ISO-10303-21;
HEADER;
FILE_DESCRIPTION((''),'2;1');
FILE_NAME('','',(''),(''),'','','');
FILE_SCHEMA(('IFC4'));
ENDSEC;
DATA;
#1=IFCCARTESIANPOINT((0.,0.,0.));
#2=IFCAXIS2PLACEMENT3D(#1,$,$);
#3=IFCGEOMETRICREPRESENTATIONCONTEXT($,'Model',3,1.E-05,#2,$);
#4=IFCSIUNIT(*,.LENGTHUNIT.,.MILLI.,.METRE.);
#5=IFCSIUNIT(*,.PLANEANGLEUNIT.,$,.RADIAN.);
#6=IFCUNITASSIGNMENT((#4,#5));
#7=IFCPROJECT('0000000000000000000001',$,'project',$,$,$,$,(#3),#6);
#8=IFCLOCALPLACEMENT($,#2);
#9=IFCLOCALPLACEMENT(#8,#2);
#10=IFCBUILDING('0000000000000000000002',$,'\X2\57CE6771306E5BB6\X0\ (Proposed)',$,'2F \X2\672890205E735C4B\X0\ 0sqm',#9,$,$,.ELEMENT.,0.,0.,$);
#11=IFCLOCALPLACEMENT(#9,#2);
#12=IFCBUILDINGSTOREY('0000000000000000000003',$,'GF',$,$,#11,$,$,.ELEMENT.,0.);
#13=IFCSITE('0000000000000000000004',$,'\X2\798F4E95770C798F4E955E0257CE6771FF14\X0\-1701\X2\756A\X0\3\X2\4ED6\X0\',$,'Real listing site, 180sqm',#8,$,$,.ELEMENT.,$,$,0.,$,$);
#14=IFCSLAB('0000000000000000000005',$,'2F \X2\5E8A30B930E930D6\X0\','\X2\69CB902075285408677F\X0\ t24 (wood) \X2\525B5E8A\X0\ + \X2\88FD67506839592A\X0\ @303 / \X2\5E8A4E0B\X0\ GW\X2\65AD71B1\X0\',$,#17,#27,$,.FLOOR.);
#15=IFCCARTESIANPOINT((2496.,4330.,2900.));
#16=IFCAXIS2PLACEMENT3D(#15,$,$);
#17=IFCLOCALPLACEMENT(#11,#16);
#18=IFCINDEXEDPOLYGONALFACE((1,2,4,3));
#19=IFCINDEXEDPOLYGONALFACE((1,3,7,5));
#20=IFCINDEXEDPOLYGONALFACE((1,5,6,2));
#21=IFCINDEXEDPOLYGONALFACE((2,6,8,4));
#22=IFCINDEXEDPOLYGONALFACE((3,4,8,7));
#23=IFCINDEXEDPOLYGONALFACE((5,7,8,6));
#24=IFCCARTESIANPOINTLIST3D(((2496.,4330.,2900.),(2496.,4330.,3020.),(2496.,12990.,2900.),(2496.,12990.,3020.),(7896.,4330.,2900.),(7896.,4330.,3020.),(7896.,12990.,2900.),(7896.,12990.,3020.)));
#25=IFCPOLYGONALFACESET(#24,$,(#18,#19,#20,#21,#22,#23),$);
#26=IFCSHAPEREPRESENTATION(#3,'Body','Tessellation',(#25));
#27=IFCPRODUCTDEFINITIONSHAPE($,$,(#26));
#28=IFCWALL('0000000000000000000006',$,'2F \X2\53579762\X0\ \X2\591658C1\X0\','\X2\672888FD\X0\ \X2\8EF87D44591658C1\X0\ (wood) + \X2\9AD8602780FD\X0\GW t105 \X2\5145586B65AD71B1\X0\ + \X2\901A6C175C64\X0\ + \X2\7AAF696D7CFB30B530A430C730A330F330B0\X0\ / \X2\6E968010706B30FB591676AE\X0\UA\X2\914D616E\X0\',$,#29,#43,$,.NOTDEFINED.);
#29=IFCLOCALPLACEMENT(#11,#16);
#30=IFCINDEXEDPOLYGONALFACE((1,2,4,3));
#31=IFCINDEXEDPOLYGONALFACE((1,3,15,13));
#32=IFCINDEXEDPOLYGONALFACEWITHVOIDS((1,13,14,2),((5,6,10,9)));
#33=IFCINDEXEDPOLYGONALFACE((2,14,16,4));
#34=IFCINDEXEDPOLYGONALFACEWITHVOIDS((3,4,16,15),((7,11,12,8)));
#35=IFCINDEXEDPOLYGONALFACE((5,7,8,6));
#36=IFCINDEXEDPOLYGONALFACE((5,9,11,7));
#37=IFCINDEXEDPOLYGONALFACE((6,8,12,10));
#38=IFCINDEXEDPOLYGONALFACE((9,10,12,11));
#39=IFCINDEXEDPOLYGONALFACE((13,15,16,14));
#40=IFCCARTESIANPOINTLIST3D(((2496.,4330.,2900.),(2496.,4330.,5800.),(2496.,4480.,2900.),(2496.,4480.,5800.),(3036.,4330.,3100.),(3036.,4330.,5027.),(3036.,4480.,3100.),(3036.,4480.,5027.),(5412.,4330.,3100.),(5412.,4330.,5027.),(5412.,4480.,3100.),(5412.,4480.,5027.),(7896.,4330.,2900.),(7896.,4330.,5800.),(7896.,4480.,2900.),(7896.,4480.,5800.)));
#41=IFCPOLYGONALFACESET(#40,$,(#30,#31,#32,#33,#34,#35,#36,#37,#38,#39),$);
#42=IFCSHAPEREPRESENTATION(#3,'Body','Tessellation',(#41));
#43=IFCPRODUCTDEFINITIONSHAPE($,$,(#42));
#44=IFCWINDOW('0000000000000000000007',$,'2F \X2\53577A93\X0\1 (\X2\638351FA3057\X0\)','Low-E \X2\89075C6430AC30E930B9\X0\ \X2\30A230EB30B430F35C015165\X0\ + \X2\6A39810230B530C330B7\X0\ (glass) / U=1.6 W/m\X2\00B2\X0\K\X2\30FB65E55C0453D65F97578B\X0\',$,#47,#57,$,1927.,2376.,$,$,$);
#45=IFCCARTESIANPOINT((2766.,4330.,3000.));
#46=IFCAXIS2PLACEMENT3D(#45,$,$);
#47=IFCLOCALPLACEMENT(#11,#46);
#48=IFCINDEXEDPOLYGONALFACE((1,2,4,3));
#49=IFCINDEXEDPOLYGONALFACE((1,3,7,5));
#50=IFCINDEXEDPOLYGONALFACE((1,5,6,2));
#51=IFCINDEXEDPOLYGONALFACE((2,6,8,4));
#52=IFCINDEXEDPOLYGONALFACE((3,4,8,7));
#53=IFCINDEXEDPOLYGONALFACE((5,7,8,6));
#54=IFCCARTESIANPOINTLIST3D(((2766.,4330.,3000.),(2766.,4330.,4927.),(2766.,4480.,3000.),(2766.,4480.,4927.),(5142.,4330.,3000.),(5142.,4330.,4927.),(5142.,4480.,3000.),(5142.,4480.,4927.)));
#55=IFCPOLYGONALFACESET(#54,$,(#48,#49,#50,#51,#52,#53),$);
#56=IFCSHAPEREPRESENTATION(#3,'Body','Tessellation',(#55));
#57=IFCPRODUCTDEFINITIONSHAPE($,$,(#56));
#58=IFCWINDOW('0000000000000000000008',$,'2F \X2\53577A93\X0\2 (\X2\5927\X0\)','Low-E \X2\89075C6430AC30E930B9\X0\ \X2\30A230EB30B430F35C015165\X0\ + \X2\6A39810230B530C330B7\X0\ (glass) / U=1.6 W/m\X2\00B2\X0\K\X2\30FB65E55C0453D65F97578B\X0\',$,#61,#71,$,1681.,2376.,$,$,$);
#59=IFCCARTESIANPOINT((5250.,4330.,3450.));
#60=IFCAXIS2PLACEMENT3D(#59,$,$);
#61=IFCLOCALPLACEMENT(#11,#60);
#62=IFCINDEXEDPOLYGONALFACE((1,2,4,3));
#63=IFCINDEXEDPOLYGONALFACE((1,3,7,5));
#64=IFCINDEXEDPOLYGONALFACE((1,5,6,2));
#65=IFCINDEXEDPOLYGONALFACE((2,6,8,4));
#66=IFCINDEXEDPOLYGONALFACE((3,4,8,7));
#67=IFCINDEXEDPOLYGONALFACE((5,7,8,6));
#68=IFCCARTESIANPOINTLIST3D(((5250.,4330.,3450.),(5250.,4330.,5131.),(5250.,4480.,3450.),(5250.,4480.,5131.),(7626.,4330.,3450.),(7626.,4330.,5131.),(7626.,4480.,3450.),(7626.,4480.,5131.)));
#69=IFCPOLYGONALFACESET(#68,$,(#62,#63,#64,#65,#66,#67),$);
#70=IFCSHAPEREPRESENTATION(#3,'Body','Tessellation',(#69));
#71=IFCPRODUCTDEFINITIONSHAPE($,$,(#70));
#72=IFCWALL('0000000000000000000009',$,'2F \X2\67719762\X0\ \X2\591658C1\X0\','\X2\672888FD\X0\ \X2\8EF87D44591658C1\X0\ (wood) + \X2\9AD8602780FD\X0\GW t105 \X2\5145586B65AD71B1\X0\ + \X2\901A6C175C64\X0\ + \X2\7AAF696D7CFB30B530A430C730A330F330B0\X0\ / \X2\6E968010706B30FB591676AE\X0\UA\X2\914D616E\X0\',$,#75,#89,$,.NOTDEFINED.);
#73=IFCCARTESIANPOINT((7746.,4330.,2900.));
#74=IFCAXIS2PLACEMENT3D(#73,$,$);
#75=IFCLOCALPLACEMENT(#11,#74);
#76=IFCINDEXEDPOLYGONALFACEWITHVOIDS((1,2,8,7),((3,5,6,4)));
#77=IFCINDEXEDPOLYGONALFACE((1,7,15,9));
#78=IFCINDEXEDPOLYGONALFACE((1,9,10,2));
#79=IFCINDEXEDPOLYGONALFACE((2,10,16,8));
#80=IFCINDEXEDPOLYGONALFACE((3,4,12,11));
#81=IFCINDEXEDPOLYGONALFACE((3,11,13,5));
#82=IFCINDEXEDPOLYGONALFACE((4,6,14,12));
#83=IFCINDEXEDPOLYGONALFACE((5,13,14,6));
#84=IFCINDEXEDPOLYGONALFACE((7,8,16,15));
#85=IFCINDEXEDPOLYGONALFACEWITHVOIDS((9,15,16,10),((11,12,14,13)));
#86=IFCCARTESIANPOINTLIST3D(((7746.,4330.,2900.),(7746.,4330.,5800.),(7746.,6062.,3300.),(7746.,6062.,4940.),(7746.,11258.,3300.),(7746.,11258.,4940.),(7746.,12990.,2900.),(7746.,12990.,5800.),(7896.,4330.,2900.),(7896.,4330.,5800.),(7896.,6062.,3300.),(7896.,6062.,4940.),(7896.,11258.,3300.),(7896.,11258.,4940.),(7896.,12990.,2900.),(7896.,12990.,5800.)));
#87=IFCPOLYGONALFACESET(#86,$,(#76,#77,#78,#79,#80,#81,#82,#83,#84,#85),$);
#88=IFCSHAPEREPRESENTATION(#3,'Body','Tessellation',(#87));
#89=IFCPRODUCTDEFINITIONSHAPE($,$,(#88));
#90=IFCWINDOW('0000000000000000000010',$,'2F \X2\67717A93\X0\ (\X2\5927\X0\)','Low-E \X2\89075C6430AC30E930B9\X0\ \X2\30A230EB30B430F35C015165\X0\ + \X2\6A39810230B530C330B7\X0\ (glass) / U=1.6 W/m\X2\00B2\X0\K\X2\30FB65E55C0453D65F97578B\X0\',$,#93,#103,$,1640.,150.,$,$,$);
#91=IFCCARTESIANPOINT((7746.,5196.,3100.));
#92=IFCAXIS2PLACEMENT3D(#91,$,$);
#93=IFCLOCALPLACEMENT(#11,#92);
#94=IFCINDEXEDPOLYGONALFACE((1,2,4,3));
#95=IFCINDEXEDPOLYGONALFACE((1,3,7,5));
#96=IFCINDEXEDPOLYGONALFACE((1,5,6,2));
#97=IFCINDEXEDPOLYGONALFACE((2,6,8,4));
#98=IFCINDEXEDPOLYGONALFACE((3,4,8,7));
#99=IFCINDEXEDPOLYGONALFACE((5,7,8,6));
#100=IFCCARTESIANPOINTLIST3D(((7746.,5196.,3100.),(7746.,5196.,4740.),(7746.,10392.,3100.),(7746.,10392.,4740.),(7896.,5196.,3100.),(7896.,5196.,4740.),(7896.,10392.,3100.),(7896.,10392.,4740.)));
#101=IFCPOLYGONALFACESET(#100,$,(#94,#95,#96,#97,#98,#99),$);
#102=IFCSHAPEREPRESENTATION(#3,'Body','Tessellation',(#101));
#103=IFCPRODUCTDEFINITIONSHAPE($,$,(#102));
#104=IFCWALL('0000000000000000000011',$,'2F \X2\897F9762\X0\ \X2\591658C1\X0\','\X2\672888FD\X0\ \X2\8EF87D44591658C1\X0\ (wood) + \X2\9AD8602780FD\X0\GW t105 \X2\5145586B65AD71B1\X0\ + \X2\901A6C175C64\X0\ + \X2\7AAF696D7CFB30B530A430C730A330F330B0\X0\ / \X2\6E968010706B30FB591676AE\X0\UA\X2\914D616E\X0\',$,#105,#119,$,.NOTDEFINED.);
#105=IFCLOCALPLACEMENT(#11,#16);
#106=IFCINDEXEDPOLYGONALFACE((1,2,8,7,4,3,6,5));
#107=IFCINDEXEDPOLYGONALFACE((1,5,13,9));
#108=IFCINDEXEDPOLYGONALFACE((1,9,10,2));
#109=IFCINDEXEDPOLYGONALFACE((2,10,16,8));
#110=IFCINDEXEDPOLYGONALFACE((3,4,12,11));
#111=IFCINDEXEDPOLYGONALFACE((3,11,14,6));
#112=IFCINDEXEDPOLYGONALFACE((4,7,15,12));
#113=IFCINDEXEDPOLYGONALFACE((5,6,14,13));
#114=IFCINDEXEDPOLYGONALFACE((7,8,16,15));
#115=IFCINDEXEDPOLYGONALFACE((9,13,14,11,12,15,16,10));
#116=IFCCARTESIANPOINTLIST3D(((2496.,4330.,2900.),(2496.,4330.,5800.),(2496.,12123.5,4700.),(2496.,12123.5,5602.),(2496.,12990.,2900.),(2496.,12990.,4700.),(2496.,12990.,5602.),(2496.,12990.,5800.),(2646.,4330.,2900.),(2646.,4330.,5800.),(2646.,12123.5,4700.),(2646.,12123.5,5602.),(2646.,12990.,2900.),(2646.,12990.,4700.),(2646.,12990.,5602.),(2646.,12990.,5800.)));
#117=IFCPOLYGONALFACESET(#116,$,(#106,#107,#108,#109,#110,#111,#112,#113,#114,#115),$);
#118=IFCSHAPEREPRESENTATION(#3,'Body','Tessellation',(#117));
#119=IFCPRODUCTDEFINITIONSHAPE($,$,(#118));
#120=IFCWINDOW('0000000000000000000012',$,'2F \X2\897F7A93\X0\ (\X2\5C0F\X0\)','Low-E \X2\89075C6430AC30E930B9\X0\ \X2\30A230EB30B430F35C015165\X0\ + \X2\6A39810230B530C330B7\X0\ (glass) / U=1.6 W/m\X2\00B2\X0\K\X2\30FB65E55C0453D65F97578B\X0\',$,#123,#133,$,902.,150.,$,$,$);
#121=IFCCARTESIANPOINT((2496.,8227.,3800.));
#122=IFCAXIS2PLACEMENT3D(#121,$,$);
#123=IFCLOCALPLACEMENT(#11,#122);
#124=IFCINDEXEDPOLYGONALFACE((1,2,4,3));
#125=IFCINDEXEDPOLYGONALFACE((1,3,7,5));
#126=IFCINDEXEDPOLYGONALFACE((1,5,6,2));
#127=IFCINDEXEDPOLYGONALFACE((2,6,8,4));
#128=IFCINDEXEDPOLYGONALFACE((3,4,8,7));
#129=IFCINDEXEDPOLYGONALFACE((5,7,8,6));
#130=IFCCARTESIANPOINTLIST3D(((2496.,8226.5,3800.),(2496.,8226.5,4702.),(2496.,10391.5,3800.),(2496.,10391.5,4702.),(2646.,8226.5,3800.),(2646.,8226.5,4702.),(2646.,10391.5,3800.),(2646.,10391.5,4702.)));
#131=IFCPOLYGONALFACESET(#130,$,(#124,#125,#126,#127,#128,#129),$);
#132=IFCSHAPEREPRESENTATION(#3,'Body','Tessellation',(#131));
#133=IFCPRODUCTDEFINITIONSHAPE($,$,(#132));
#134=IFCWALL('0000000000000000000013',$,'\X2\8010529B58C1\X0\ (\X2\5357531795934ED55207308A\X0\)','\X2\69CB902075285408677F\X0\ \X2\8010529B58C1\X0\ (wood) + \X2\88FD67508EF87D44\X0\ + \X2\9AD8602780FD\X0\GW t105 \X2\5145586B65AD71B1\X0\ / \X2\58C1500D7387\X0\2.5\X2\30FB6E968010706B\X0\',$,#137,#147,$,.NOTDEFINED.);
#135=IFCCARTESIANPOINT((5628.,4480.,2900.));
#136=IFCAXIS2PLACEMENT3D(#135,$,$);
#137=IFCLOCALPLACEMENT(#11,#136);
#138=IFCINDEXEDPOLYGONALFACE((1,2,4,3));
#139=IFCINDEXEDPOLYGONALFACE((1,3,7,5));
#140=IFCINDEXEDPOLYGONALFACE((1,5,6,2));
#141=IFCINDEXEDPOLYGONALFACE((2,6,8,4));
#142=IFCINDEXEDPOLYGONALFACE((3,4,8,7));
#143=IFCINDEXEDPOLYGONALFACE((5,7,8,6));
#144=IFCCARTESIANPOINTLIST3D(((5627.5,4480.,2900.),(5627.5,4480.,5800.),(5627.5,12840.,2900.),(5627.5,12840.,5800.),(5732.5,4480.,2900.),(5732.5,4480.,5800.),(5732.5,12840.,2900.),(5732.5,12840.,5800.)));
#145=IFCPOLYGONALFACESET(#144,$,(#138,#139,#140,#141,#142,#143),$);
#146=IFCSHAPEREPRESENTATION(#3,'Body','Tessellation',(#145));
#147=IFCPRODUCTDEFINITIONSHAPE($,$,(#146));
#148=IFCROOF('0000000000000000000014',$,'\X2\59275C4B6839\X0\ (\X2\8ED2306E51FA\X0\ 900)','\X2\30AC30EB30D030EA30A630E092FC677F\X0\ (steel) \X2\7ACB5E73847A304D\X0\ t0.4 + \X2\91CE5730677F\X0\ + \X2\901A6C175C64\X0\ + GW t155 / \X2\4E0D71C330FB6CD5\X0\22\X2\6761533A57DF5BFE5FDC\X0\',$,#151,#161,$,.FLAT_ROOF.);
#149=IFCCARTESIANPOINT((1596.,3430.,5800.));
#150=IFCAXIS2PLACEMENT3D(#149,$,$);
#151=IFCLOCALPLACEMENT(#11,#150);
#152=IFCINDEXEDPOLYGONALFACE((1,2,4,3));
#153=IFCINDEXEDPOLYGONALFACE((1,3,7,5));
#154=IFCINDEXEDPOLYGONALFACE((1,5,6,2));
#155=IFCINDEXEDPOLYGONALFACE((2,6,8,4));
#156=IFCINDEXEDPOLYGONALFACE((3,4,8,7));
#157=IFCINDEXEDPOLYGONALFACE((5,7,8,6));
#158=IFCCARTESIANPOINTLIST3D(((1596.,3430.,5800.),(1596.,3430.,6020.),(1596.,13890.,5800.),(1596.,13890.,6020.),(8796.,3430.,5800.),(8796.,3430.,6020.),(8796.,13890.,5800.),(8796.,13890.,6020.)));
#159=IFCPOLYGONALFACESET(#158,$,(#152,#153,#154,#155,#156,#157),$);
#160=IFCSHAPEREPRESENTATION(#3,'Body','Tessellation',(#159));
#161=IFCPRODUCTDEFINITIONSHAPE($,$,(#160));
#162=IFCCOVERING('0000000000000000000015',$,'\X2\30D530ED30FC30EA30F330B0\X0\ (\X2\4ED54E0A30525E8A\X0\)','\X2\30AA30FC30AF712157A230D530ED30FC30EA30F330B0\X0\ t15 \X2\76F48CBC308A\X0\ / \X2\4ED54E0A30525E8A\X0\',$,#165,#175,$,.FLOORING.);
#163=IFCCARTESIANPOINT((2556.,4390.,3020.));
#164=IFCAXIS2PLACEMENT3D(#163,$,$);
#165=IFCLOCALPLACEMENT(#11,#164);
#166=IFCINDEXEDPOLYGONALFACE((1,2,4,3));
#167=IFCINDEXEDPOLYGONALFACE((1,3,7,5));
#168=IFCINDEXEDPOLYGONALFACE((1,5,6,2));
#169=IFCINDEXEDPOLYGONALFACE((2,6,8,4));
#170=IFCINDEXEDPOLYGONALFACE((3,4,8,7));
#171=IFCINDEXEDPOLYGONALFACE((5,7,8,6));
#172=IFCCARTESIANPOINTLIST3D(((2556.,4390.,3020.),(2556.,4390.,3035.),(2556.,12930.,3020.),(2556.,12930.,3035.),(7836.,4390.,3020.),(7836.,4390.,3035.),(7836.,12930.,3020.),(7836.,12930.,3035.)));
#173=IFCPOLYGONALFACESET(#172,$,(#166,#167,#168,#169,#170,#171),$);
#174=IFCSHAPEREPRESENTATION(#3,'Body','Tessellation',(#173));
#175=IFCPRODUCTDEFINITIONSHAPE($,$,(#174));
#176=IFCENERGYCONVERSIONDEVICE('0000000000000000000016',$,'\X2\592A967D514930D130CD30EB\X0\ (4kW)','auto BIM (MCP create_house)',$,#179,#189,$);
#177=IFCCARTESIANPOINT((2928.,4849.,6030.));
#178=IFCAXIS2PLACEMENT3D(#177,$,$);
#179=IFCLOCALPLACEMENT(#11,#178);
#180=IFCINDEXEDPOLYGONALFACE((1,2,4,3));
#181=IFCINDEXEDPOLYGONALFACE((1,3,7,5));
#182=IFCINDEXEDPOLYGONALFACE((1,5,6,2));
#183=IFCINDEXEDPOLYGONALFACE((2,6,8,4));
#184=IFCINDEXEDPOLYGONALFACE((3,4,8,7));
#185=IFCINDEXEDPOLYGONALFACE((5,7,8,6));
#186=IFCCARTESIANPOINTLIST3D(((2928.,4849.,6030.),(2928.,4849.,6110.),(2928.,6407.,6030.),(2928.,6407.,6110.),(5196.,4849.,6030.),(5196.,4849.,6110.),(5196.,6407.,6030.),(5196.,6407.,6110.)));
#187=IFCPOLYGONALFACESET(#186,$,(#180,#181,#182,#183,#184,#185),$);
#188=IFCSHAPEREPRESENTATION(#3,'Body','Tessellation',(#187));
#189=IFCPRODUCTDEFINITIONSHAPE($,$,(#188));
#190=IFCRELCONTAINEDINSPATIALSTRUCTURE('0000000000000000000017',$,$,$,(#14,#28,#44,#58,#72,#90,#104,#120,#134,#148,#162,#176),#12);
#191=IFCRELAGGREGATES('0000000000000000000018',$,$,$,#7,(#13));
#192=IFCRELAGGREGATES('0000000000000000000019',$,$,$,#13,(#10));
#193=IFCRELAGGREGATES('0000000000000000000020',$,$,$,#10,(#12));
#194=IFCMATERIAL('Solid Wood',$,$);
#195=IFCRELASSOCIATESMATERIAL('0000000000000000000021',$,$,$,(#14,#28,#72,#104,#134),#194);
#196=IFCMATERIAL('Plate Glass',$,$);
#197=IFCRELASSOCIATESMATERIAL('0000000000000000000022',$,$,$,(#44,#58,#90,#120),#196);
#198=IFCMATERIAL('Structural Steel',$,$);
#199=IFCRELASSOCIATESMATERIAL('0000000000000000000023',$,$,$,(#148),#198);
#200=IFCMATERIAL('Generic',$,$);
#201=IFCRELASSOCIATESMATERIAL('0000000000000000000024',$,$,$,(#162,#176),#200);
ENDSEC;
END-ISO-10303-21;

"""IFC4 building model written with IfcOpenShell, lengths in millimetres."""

from ifc_helpers import new_model, si_unit, frame, frame_2d, origin, place, context, project, spatial, rectangle, extrude, material, element, fill, save


model = new_model("IFC4")

# Units and contexts
model_context = context("Model", 3, precision=1e-05, world=origin())
ifc_project = project(units=[si_unit("LENGTHUNIT", "METRE", prefix="MILLI"), si_unit("PLANEANGLEUNIT", "RADIAN")], contexts=[model_context])

# Site, building, storey
site_placement = place(None, origin())
site = spatial("IfcSite", under=ifc_project, at=site_placement, Name="福井県福井市城東４-1701番3他", ObjectType="Real listing site, 180sqm", CompositionType="ELEMENT", RefElevation=0.0)
building_placement = place(site_placement, origin())
building = spatial("IfcBuilding", under=site, at=building_placement, Name="城東の家 (Proposed)", ObjectType="2F 木造平屋 0sqm", CompositionType="ELEMENT", ElevationOfRefHeight=0.0, ElevationOfTerrain=0.0)
storey_placement = place(building_placement, origin())
storey = spatial("IfcBuildingStorey", under=building, at=storey_placement, Name="GF", CompositionType="ELEMENT", Elevation=0.0)

# Slab
ifc_material_1 = material(Name="Solid Wood")
slab_placement = place(storey_placement, frame((2496.0, 4330.0, 2900.0)))
element("IfcSlab", 1, at=slab_placement, inside=storey, material=ifc_material_1, Name="2F 床スラブ", Description="構造用合板 t24 (wood) 剛床 + 製材根太 @303 / 床下 GW断熱", PredefinedType="FLOOR", context=model_context, shape_type="SweptSolid", body=[
    extrude(rectangle(XDim=5400.0, YDim=8660.0, at=frame_2d((2700.0, 4330.0))), frame((2496.0, 4330.0, 2900.0)), (0.0, 0.0, 1.0), 120.0),
])

# Wall, openings, windows
wall_1_placement = place(storey_placement, frame((2496.0, 4330.0, 2900.0)))
wall_1 = element("IfcWall", 2, at=wall_1_placement, inside=storey, material=ifc_material_1, Name="2F 南面 外壁", Description="木製 軸組外壁 (wood) + 高性能GW t105 充填断熱 + 通気層 + 窯業系サイディング / 準耐火・外皮UA配慮", PredefinedType="NOTDEFINED", context=model_context, shape_type="SweptSolid", body=[
    extrude(rectangle(XDim=5400.0, YDim=150.0, at=frame_2d((2700.0, 75.0))), frame((2496.0, 4330.0, 2900.0)), (0.0, 0.0, 1.0), 2900.0),
])
opening_1_placement = place(storey_placement, frame((2766.0, 4330.0, 3000.0)))
opening_1 = element("IfcOpeningElement", 3, at=opening_1_placement, cuts=wall_1, PredefinedType="NOTDEFINED", context=model_context, shape_type="SweptSolid", body=[
    extrude(rectangle(XDim=2376.0, YDim=150.0, at=frame_2d((1188.0, 75.0))), frame((2766.0, 4330.0, 3000.0)), (0.0, 0.0, 1.0), 1927.0),
])
opening_2_placement = place(storey_placement, frame((5250.0, 4330.0, 3450.0)))
opening_2 = element("IfcOpeningElement", 4, at=opening_2_placement, cuts=wall_1, PredefinedType="NOTDEFINED", context=model_context, shape_type="SweptSolid", body=[
    extrude(rectangle(XDim=2376.0, YDim=150.0, at=frame_2d((1188.0, 75.0))), frame((5250.0, 4330.0, 3450.0)), (0.0, 0.0, 1.0), 1681.0),
])
ifc_material_2 = material(Name="Plate Glass")
window_1_placement = place(storey_placement, frame((2766.0, 4330.0, 3000.0)))
window_1 = element("IfcWindow", 5, at=window_1_placement, inside=storey, material=ifc_material_2, Name="2F 南窓1 (掃出し)", Description="Low-E 複層ガラス アルゴン封入 + 樹脂サッシ (glass) / U=1.6 W/m²K・日射取得型", OverallHeight=1927.0, OverallWidth=2376.0, context=model_context, shape_type="SweptSolid", body=[
    extrude(rectangle(XDim=2376.0, YDim=150.0, at=frame_2d((1188.0, 75.0))), frame((2766.0, 4330.0, 3000.0)), (0.0, 0.0, 1.0), 1927.0),
])
fill(opening_1, window_1)
window_2_placement = place(storey_placement, frame((5250.0, 4330.0, 3450.0)))
window_2 = element("IfcWindow", 6, at=window_2_placement, inside=storey, material=ifc_material_2, Name="2F 南窓2 (大)", Description="Low-E 複層ガラス アルゴン封入 + 樹脂サッシ (glass) / U=1.6 W/m²K・日射取得型", OverallHeight=1681.0, OverallWidth=2376.0, context=model_context, shape_type="SweptSolid", body=[
    extrude(rectangle(XDim=2376.0, YDim=150.0, at=frame_2d((1188.0, 75.0))), frame((5250.0, 4330.0, 3450.0)), (0.0, 0.0, 1.0), 1681.0),
])
fill(opening_2, window_2)

# Walls, openings, windows
wall_2_placement = place(storey_placement, frame((7746.0, 4330.0, 2900.0)))
wall_2 = element("IfcWall", 7, at=wall_2_placement, inside=storey, material=ifc_material_1, Name="2F 東面 外壁", Description="木製 軸組外壁 (wood) + 高性能GW t105 充填断熱 + 通気層 + 窯業系サイディング / 準耐火・外皮UA配慮", PredefinedType="NOTDEFINED", context=model_context, shape_type="SweptSolid", body=[
    extrude(rectangle(XDim=150.0, YDim=8660.0, at=frame_2d((75.0, 4330.0))), frame((7746.0, 4330.0, 2900.0)), (0.0, 0.0, 1.0), 2900.0),
])
opening_3_placement = place(storey_placement, frame((7746.0, 5196.0, 3100.0)))
opening_3 = element("IfcOpeningElement", 8, at=opening_3_placement, cuts=wall_2, PredefinedType="NOTDEFINED", context=model_context, shape_type="SweptSolid", body=[
    extrude(rectangle(XDim=150.0, YDim=5196.0, at=frame_2d((75.0, 2598.0))), frame((7746.0, 5196.0, 3100.0)), (0.0, 0.0, 1.0), 1640.0),
])
window_3_placement = place(storey_placement, frame((7746.0, 5196.0, 3100.0)))
window_3 = element("IfcWindow", 9, at=window_3_placement, inside=storey, material=ifc_material_2, Name="2F 東窓 (大)", Description="Low-E 複層ガラス アルゴン封入 + 樹脂サッシ (glass) / U=1.6 W/m²K・日射取得型", OverallHeight=1640.0, OverallWidth=150.0, context=model_context, shape_type="SweptSolid", body=[
    extrude(rectangle(XDim=150.0, YDim=5196.0, at=frame_2d((75.0, 2598.0))), frame((7746.0, 5196.0, 3100.0)), (0.0, 0.0, 1.0), 1640.0),
])
fill(opening_3, window_3)
wall_3_placement = place(storey_placement, frame((2496.0, 4330.0, 2900.0)))
wall_3 = element("IfcWall", 10, at=wall_3_placement, inside=storey, material=ifc_material_1, Name="2F 西面 外壁", Description="木製 軸組外壁 (wood) + 高性能GW t105 充填断熱 + 通気層 + 窯業系サイディング / 準耐火・外皮UA配慮", PredefinedType="NOTDEFINED", context=model_context, shape_type="SweptSolid", body=[
    extrude(rectangle(XDim=150.0, YDim=8660.0, at=frame_2d((75.0, 4330.0))), frame((2496.0, 4330.0, 2900.0)), (0.0, 0.0, 1.0), 2900.0),
])
opening_4_placement = place(storey_placement, frame((2496.0, 8227.0, 3800.0)))
opening_4 = element("IfcOpeningElement", 11, at=opening_4_placement, cuts=wall_3, PredefinedType="NOTDEFINED", context=model_context, shape_type="SweptSolid", body=[
    extrude(rectangle(XDim=150.0, YDim=2165.0, at=frame_2d((75.0, 1082.0))), frame((2496.0, 8227.0, 3800.0)), (0.0, 0.0, 1.0), 902.0),
])
window_4_placement = place(storey_placement, frame((2496.0, 8227.0, 3800.0)))
window_4 = element("IfcWindow", 12, at=window_4_placement, inside=storey, material=ifc_material_2, Name="2F 西窓 (小)", Description="Low-E 複層ガラス アルゴン封入 + 樹脂サッシ (glass) / U=1.6 W/m²K・日射取得型", OverallHeight=902.0, OverallWidth=150.0, context=model_context, shape_type="SweptSolid", body=[
    extrude(rectangle(XDim=150.0, YDim=2165.0, at=frame_2d((75.0, 1082.0))), frame((2496.0, 8227.0, 3800.0)), (0.0, 0.0, 1.0), 902.0),
])
fill(opening_4, window_4)

# Wall
wall_4_placement = place(storey_placement, frame((5628.0, 4480.0, 2900.0)))
element("IfcWall", 13, at=wall_4_placement, inside=storey, material=ifc_material_1, Name="耐力壁 (南北間仕切り)", Description="構造用合板 耐力壁 (wood) + 製材軸組 + 高性能GW t105 充填断熱 / 壁倍率2.5・準耐火", PredefinedType="NOTDEFINED", context=model_context, shape_type="SweptSolid", body=[
    extrude(rectangle(XDim=105.0, YDim=8360.0, at=frame_2d((52.0, 4180.0))), frame((5628.0, 4480.0, 2900.0)), (0.0, 0.0, 1.0), 2900.0),
])

# Roof
ifc_material_3 = material(Name="Structural Steel")
roof_placement = place(storey_placement, frame((1596.0, 3430.0, 5800.0)))
element("IfcRoof", 14, at=roof_placement, inside=storey, material=ifc_material_3, Name="大屋根 (軒の出 900)", Description="ガルバリウム鋼板 (steel) 立平葺き t0.4 + 野地板 + 通気層 + GW t155 / 不燃・法22条区域対応", PredefinedType="FLAT_ROOF", context=model_context, shape_type="SweptSolid", body=[
    extrude(rectangle(XDim=7200.0, YDim=10460.0, at=frame_2d((3600.0, 5230.0))), frame((1596.0, 3430.0, 5800.0)), (0.0, 0.0, 1.0), 220.0),
])

# Covering
ifc_material_4 = material(Name="Generic")
covering_placement = place(storey_placement, frame((2556.0, 4390.0, 3020.0)))
element("IfcCovering", 15, at=covering_placement, inside=storey, material=ifc_material_4, Name="フローリング (仕上げ床)", Description="オーク無垢フローリング t15 直貼り / 仕上げ床", PredefinedType="FLOORING", context=model_context, shape_type="SweptSolid", body=[
    extrude(rectangle(XDim=5280.0, YDim=8540.0, at=frame_2d((2640.0, 4270.0))), frame((2556.0, 4390.0, 3020.0)), (0.0, 0.0, 1.0), 15.0),
])

# Energy conversion device
energy_conversion_device_placement = place(storey_placement, frame((2928.0, 4849.0, 6030.0)))
element("IfcEnergyConversionDevice", 16, at=energy_conversion_device_placement, inside=storey, material=ifc_material_4, Name="太陽光パネル (4kW)", Description="auto BIM (MCP create_house)", context=model_context, shape_type="SweptSolid", body=[
    extrude(rectangle(XDim=2268.0, YDim=1558.0, at=frame_2d((1134.0, 779.0))), frame((2928.0, 4849.0, 6030.0)), (0.0, 0.0, 1.0), 80.0),
])

save(model, "model.ifc")
